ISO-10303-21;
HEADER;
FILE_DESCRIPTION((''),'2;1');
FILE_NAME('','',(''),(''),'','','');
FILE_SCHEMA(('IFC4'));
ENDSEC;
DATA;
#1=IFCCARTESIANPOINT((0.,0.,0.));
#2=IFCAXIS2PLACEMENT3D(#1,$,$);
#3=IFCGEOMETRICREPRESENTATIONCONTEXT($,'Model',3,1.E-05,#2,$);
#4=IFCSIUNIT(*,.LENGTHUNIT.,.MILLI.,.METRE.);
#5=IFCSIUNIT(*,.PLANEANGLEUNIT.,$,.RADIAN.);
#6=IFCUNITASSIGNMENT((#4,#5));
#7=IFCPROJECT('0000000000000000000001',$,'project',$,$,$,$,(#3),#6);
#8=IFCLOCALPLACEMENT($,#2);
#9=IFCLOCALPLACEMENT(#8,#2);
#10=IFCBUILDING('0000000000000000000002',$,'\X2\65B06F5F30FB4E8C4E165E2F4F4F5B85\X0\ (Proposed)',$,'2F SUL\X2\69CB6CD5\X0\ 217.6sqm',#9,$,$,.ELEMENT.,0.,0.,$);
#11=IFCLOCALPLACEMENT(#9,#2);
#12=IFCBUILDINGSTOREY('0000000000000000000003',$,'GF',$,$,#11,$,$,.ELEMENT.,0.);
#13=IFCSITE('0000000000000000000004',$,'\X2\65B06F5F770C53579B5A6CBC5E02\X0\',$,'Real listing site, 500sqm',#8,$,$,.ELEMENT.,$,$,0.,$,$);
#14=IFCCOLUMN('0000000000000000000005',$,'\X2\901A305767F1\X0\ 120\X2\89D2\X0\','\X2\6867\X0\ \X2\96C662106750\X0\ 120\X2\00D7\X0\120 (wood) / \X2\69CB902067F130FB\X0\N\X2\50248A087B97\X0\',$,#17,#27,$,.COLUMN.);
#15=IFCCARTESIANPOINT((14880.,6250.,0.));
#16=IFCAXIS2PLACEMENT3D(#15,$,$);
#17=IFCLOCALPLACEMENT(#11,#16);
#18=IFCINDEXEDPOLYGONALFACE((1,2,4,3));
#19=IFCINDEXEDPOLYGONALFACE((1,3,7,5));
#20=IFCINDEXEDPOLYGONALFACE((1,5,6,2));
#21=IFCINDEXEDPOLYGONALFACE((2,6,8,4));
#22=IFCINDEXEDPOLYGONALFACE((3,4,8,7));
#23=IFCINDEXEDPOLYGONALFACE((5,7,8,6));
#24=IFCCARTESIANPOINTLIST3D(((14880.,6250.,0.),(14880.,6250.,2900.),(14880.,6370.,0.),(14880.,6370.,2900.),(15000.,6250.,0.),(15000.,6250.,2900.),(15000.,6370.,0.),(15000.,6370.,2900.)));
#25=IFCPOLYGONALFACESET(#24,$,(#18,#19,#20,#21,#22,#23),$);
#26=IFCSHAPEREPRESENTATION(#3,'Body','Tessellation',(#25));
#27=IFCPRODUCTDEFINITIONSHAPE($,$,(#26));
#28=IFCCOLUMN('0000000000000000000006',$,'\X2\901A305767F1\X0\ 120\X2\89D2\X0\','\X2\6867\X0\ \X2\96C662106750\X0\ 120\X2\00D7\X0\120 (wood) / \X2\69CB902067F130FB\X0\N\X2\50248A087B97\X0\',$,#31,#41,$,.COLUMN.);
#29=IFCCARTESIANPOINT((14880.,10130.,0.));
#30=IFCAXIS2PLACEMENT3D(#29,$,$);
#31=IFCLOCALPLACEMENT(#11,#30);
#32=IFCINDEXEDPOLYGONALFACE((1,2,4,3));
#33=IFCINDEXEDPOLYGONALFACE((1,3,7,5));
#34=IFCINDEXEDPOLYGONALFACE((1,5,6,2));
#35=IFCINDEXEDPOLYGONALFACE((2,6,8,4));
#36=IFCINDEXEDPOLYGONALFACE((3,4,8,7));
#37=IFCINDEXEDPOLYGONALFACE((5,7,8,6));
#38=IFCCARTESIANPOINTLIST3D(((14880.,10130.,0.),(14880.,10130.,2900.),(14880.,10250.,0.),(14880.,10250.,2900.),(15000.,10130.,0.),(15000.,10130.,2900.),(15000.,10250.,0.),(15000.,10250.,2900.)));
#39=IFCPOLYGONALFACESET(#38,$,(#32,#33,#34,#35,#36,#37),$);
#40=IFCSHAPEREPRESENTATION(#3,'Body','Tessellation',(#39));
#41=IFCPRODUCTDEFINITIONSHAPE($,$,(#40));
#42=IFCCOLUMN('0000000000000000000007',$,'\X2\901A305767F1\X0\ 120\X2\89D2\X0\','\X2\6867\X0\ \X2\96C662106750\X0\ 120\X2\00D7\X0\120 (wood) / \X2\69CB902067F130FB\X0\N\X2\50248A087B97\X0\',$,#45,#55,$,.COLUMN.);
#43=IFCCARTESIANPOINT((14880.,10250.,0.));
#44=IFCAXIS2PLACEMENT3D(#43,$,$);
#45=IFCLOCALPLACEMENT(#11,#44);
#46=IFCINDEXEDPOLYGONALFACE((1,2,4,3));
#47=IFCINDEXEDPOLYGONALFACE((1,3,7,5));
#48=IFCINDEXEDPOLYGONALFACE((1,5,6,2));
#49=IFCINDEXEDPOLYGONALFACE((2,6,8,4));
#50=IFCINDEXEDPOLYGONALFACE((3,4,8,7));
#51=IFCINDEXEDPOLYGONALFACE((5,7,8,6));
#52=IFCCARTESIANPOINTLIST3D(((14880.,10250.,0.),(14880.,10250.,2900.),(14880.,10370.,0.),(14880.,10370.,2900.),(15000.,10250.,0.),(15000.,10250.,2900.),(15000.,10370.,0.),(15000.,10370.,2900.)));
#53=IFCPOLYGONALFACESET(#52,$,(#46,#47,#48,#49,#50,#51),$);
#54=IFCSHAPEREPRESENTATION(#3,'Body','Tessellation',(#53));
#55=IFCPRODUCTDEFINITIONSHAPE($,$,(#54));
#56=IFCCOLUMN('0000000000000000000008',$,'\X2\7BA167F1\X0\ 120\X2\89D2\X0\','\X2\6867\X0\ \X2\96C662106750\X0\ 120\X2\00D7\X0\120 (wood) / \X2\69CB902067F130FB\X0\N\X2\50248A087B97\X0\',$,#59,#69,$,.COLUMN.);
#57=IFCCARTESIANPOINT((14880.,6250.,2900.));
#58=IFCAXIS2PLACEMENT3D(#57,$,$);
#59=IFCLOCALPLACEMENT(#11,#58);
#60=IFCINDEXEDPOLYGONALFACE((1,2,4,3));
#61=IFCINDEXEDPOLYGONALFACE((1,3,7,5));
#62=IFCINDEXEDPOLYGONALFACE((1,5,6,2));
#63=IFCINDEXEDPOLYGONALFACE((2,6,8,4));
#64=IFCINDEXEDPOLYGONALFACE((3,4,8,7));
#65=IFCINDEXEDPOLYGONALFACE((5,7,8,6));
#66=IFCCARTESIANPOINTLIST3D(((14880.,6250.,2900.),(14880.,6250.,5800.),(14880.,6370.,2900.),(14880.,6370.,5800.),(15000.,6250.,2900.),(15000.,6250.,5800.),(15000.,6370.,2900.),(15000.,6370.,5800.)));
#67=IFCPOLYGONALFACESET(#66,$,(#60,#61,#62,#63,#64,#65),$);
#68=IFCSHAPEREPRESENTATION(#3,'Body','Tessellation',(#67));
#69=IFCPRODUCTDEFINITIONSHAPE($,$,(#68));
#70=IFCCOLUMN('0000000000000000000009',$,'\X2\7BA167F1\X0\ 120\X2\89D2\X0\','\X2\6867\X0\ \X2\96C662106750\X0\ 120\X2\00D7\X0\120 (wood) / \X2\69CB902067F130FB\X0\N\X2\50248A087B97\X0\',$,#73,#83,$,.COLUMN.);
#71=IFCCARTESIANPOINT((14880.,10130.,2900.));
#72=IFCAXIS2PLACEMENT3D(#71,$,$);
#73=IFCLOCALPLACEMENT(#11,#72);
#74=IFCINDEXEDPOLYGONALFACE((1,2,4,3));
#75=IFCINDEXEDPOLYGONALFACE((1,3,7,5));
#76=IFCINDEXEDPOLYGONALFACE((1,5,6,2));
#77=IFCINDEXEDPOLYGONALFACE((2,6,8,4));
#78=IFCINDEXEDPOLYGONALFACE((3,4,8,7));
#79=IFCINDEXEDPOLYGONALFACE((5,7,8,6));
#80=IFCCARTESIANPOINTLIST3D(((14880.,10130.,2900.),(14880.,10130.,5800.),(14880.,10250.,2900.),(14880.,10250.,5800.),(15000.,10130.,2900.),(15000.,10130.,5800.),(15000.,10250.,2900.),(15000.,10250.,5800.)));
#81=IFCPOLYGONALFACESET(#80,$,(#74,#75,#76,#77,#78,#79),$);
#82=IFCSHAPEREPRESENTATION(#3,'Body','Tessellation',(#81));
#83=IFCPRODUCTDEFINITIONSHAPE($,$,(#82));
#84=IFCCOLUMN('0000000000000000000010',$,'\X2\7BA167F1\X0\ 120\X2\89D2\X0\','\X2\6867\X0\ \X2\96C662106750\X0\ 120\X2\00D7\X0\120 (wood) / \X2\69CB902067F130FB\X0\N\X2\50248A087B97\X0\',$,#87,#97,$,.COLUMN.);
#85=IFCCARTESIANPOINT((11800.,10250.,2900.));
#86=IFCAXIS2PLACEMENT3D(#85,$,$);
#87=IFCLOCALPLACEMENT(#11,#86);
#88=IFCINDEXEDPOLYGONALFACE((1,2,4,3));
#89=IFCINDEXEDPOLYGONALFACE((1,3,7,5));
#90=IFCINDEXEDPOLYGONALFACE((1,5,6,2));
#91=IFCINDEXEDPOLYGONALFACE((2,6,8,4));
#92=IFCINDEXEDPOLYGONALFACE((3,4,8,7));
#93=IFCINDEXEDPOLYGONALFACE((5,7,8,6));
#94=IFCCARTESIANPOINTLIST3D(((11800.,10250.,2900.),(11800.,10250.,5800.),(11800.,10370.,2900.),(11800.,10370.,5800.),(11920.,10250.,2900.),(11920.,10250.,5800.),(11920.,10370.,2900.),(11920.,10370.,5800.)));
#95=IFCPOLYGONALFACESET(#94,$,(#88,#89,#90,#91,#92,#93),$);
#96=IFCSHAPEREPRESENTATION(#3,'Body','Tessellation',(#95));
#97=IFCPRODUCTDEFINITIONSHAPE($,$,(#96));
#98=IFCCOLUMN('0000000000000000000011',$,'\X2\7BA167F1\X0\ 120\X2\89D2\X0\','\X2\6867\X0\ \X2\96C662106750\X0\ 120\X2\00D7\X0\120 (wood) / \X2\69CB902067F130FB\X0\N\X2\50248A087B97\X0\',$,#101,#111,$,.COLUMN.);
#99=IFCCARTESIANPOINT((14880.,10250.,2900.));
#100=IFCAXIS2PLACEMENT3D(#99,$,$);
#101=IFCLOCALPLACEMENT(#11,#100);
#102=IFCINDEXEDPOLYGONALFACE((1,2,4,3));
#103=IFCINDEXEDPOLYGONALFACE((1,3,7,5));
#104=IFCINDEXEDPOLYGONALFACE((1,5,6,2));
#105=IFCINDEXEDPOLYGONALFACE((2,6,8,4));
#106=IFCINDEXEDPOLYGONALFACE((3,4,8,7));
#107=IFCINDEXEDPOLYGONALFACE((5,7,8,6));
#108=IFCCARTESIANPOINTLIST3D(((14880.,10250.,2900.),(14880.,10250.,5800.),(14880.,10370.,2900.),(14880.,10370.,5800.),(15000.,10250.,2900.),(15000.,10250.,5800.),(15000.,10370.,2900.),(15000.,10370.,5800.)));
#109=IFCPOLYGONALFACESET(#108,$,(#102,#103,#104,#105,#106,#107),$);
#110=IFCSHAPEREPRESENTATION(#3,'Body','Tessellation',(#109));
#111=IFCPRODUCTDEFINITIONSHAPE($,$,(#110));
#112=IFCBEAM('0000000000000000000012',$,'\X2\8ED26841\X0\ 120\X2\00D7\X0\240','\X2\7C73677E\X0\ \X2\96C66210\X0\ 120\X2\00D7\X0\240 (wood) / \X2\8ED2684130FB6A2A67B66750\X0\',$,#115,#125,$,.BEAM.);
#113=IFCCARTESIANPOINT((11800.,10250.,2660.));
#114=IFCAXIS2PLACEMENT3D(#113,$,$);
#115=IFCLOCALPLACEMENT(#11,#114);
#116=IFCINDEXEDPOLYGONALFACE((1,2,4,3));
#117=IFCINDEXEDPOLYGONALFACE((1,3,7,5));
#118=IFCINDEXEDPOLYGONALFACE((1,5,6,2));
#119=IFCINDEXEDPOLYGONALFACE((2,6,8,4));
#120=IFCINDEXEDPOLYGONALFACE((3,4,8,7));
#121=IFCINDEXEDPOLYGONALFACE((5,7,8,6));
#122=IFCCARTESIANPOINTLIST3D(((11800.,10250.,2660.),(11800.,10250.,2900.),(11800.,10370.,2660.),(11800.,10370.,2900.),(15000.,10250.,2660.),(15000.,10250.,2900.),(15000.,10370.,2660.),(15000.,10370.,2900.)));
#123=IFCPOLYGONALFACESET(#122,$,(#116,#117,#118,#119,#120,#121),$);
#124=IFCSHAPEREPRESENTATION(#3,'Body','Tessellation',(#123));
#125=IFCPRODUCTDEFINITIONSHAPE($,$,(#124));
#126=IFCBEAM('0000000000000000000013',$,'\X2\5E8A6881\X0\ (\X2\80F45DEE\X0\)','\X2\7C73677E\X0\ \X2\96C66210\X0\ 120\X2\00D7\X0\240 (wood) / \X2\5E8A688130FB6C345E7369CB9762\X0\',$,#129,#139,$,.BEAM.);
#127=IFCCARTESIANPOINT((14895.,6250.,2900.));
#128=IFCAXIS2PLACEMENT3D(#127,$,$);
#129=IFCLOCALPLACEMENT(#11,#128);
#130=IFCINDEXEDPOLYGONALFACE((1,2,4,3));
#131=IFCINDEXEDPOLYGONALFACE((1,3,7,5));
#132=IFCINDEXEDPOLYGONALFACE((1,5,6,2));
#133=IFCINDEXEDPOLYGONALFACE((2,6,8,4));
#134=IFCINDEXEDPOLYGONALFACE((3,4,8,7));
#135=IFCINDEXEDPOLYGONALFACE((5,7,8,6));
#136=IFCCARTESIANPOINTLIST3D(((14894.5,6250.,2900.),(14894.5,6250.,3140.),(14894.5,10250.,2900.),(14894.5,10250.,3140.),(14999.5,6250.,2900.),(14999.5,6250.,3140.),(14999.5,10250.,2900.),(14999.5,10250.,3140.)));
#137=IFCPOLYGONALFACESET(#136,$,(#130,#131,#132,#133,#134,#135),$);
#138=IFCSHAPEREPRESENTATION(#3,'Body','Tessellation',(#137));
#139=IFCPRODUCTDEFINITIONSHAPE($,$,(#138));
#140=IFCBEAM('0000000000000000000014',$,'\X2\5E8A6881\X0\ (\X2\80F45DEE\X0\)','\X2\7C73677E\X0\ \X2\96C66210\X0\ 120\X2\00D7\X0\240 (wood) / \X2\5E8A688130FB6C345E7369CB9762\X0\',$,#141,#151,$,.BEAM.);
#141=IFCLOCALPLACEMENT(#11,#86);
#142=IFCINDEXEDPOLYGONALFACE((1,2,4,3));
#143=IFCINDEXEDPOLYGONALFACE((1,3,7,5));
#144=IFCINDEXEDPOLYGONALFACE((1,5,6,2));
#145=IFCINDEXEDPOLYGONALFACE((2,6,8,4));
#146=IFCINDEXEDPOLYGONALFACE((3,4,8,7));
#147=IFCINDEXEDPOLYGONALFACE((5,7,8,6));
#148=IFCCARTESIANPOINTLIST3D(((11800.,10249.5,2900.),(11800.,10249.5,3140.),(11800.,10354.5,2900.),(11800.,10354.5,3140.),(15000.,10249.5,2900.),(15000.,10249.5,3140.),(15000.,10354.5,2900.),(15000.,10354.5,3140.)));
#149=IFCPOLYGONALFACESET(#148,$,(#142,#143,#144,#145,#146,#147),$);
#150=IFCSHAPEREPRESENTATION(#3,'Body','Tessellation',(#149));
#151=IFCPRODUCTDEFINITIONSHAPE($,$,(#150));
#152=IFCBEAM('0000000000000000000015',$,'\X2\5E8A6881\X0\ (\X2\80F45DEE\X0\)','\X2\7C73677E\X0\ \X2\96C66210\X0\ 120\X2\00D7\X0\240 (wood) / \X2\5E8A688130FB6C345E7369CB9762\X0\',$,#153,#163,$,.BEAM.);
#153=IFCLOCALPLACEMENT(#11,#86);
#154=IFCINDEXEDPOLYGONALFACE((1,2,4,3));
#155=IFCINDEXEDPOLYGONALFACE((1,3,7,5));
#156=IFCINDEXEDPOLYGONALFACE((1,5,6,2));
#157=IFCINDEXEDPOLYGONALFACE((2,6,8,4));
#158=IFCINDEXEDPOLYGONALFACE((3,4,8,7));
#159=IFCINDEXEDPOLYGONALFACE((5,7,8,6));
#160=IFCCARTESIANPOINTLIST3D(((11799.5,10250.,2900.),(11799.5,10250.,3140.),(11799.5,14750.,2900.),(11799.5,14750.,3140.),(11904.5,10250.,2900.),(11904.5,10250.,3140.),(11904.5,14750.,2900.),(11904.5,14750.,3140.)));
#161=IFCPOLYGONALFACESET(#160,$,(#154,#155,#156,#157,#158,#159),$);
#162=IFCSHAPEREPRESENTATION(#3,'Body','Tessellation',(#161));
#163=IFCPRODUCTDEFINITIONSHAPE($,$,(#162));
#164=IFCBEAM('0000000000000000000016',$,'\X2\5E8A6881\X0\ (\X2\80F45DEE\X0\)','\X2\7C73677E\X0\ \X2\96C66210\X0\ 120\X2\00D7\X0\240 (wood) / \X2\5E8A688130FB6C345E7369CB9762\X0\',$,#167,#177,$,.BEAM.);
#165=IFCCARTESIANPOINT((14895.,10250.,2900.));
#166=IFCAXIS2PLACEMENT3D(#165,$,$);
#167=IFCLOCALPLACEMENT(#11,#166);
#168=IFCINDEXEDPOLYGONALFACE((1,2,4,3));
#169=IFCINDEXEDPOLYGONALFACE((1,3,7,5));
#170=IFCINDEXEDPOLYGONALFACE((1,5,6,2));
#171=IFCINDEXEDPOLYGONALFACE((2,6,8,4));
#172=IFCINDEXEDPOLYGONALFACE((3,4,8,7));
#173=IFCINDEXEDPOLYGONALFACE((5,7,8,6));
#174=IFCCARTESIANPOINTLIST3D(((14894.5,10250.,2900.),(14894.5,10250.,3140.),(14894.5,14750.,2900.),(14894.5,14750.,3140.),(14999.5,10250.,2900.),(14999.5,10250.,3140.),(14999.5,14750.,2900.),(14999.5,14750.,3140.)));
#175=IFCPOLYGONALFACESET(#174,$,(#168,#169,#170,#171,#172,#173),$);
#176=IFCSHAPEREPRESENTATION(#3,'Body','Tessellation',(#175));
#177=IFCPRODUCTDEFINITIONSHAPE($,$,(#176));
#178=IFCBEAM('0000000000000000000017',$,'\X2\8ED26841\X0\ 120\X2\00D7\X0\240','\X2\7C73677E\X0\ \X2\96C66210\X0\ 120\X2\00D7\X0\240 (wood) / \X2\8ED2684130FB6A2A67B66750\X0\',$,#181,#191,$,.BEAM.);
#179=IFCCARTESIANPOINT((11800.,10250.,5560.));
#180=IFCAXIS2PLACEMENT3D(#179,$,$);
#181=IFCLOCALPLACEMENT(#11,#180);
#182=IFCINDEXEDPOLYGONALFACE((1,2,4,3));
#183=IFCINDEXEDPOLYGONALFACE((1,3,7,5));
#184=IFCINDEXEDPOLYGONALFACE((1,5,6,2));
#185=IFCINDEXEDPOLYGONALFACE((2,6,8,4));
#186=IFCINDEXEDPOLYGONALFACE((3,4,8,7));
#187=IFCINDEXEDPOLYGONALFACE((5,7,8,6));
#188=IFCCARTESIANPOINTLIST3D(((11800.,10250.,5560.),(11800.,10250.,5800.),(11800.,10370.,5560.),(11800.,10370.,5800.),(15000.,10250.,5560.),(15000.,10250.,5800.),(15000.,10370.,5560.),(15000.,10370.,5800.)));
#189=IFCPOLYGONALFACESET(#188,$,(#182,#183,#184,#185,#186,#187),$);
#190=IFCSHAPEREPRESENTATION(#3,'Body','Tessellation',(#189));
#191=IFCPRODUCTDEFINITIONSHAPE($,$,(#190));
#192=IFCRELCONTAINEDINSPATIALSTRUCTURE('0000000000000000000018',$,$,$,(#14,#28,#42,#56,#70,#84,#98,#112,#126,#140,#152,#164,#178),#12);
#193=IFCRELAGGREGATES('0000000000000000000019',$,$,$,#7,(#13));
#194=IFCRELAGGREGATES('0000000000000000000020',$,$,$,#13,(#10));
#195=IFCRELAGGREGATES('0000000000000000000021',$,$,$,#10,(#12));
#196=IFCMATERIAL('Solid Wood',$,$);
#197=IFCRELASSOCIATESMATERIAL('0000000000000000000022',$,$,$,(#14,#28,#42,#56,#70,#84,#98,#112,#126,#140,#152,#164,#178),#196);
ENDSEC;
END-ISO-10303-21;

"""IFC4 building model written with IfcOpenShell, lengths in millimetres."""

from ifc_helpers import new_model, si_unit, frame, frame_2d, origin, place, context, project, spatial, rectangle, extrude, material, element, save


model = new_model("IFC4")

# Units and contexts
model_context = context("Model", 3, precision=1e-05, world=origin())
ifc_project = project(units=[si_unit("LENGTHUNIT", "METRE", prefix="MILLI"), si_unit("PLANEANGLEUNIT", "RADIAN")], contexts=[model_context])

# Site, building, storey
site_placement = place(None, origin())
site = spatial("IfcSite", under=ifc_project, at=site_placement, Name="新潟県南魚沼市", ObjectType="Real listing site, 500sqm", CompositionType="ELEMENT", RefElevation=0.0)
building_placement = place(site_placement, origin())
building = spatial("IfcBuilding", under=site, at=building_placement, Name="新潟・二世帯住宅 (Proposed)", ObjectType="2F SUL構法 217.6sqm", CompositionType="ELEMENT", ElevationOfRefHeight=0.0, ElevationOfTerrain=0.0)
storey_placement = place(building_placement, origin())
storey = spatial("IfcBuildingStorey", under=building, at=storey_placement, Name="GF", CompositionType="ELEMENT", Elevation=0.0)

# Columns
ifc_material_1 = material(Name="Solid Wood")
column_1_placement = place(storey_placement, frame((14880.0, 6250.0, 0.0)))
element("IfcColumn", 1, at=column_1_placement, inside=storey, material=ifc_material_1, Name="通し柱 120角", Description="桧 集成材 120×120 (wood) / 構造柱・N値計算", PredefinedType="COLUMN", context=model_context, shape_type="SweptSolid", body=[
    extrude(rectangle(XDim=120.0, YDim=120.0, at=frame_2d((60.0, 60.0))), frame((14880.0, 6250.0, 0.0)), (0.0, 0.0, 1.0), 2900.0),
])
column_2_placement = place(storey_placement, frame((14880.0, 10130.0, 0.0)))
element("IfcColumn", 2, at=column_2_placement, inside=storey, material=ifc_material_1, Name="通し柱 120角", Description="桧 集成材 120×120 (wood) / 構造柱・N値計算", PredefinedType="COLUMN", context=model_context, shape_type="SweptSolid", body=[
    extrude(rectangle(XDim=120.0, YDim=120.0, at=frame_2d((60.0, 60.0))), frame((14880.0, 10130.0, 0.0)), (0.0, 0.0, 1.0), 2900.0),
])
column_3_placement = place(storey_placement, frame((14880.0, 10250.0, 0.0)))
element("IfcColumn", 3, at=column_3_placement, inside=storey, material=ifc_material_1, Name="通し柱 120角", Description="桧 集成材 120×120 (wood) / 構造柱・N値計算", PredefinedType="COLUMN", context=model_context, shape_type="SweptSolid", body=[
    extrude(rectangle(XDim=120.0, YDim=120.0, at=frame_2d((60.0, 60.0))), frame((14880.0, 10250.0, 0.0)), (0.0, 0.0, 1.0), 2900.0),
])
column_4_placement = place(storey_placement, frame((14880.0, 6250.0, 2900.0)))
element("IfcColumn", 4, at=column_4_placement, inside=storey, material=ifc_material_1, Name="管柱 120角", Description="桧 集成材 120×120 (wood) / 構造柱・N値計算", PredefinedType="COLUMN", context=model_context, shape_type="SweptSolid", body=[
    extrude(rectangle(XDim=120.0, YDim=120.0, at=frame_2d((60.0, 60.0))), frame((14880.0, 6250.0, 2900.0)), (0.0, 0.0, 1.0), 2900.0),
])
column_5_placement = place(storey_placement, frame((14880.0, 10130.0, 2900.0)))
element("IfcColumn", 5, at=column_5_placement, inside=storey, material=ifc_material_1, Name="管柱 120角", Description="桧 集成材 120×120 (wood) / 構造柱・N値計算", PredefinedType="COLUMN", context=model_context, shape_type="SweptSolid", body=[
    extrude(rectangle(XDim=120.0, YDim=120.0, at=frame_2d((60.0, 60.0))), frame((14880.0, 10130.0, 2900.0)), (0.0, 0.0, 1.0), 2900.0),
])
column_6_placement = place(storey_placement, frame((11800.0, 10250.0, 2900.0)))
element("IfcColumn", 6, at=column_6_placement, inside=storey, material=ifc_material_1, Name="管柱 120角", Description="桧 集成材 120×120 (wood) / 構造柱・N値計算", PredefinedType="COLUMN", context=model_context, shape_type="SweptSolid", body=[
    extrude(rectangle(XDim=120.0, YDim=120.0, at=frame_2d((60.0, 60.0))), frame((11800.0, 10250.0, 2900.0)), (0.0, 0.0, 1.0), 2900.0),
])
column_7_placement = place(storey_placement, frame((14880.0, 10250.0, 2900.0)))
element("IfcColumn", 7, at=column_7_placement, inside=storey, material=ifc_material_1, Name="管柱 120角", Description="桧 集成材 120×120 (wood) / 構造柱・N値計算", PredefinedType="COLUMN", context=model_context, shape_type="SweptSolid", body=[
    extrude(rectangle(XDim=120.0, YDim=120.0, at=frame_2d((60.0, 60.0))), frame((14880.0, 10250.0, 2900.0)), (0.0, 0.0, 1.0), 2900.0),
])

# Beams
beam_1_placement = place(storey_placement, frame((11800.0, 10250.0, 2660.0)))
element("IfcBeam", 8, at=beam_1_placement, inside=storey, material=ifc_material_1, Name="軒桁 120×240", Description="米松 集成 120×240 (wood) / 軒桁・横架材", PredefinedType="BEAM", context=model_context, shape_type="SweptSolid", body=[
    extrude(rectangle(XDim=3200.0, YDim=120.0, at=frame_2d((1600.0, 60.0))), frame((11800.0, 10250.0, 2660.0)), (0.0, 0.0, 1.0), 240.0),
])
beam_2_placement = place(storey_placement, frame((14895.0, 6250.0, 2900.0)))
element("IfcBeam", 9, at=beam_2_placement, inside=storey, material=ifc_material_1, Name="床梁 (胴差)", Description="米松 集成 120×240 (wood) / 床梁・水平構面", PredefinedType="BEAM", context=model_context, shape_type="SweptSolid", body=[
    extrude(rectangle(XDim=105.0, YDim=4000.0, at=frame_2d((52.0, 2000.0))), frame((14895.0, 6250.0, 2900.0)), (0.0, 0.0, 1.0), 240.0),
])
beam_3_placement = place(storey_placement, frame((11800.0, 10250.0, 2900.0)))
element("IfcBeam", 10, at=beam_3_placement, inside=storey, material=ifc_material_1, Name="床梁 (胴差)", Description="米松 集成 120×240 (wood) / 床梁・水平構面", PredefinedType="BEAM", context=model_context, shape_type="SweptSolid", body=[
    extrude(rectangle(XDim=3200.0, YDim=105.0, at=frame_2d((1600.0, 52.0))), frame((11800.0, 10250.0, 2900.0)), (0.0, 0.0, 1.0), 240.0),
])
beam_4_placement = place(storey_placement, frame((11800.0, 10250.0, 2900.0)))
element("IfcBeam", 11, at=beam_4_placement, inside=storey, material=ifc_material_1, Name="床梁 (胴差)", Description="米松 集成 120×240 (wood) / 床梁・水平構面", PredefinedType="BEAM", context=model_context, shape_type="SweptSolid", body=[
    extrude(rectangle(XDim=105.0, YDim=4500.0, at=frame_2d((52.0, 2250.0))), frame((11800.0, 10250.0, 2900.0)), (0.0, 0.0, 1.0), 240.0),
])
beam_5_placement = place(storey_placement, frame((14895.0, 10250.0, 2900.0)))
element("IfcBeam", 12, at=beam_5_placement, inside=storey, material=ifc_material_1, Name="床梁 (胴差)", Description="米松 集成 120×240 (wood) / 床梁・水平構面", PredefinedType="BEAM", context=model_context, shape_type="SweptSolid", body=[
    extrude(rectangle(XDim=105.0, YDim=4500.0, at=frame_2d((52.0, 2250.0))), frame((14895.0, 10250.0, 2900.0)), (0.0, 0.0, 1.0), 240.0),
])
beam_6_placement = place(storey_placement, frame((11800.0, 10250.0, 5560.0)))
element("IfcBeam", 13, at=beam_6_placement, inside=storey, material=ifc_material_1, Name="軒桁 120×240", Description="米松 集成 120×240 (wood) / 軒桁・横架材", PredefinedType="BEAM", context=model_context, shape_type="SweptSolid", body=[
    extrude(rectangle(XDim=3200.0, YDim=120.0, at=frame_2d((1600.0, 60.0))), frame((11800.0, 10250.0, 5560.0)), (0.0, 0.0, 1.0), 240.0),
])

save(model, "model.ifc")
